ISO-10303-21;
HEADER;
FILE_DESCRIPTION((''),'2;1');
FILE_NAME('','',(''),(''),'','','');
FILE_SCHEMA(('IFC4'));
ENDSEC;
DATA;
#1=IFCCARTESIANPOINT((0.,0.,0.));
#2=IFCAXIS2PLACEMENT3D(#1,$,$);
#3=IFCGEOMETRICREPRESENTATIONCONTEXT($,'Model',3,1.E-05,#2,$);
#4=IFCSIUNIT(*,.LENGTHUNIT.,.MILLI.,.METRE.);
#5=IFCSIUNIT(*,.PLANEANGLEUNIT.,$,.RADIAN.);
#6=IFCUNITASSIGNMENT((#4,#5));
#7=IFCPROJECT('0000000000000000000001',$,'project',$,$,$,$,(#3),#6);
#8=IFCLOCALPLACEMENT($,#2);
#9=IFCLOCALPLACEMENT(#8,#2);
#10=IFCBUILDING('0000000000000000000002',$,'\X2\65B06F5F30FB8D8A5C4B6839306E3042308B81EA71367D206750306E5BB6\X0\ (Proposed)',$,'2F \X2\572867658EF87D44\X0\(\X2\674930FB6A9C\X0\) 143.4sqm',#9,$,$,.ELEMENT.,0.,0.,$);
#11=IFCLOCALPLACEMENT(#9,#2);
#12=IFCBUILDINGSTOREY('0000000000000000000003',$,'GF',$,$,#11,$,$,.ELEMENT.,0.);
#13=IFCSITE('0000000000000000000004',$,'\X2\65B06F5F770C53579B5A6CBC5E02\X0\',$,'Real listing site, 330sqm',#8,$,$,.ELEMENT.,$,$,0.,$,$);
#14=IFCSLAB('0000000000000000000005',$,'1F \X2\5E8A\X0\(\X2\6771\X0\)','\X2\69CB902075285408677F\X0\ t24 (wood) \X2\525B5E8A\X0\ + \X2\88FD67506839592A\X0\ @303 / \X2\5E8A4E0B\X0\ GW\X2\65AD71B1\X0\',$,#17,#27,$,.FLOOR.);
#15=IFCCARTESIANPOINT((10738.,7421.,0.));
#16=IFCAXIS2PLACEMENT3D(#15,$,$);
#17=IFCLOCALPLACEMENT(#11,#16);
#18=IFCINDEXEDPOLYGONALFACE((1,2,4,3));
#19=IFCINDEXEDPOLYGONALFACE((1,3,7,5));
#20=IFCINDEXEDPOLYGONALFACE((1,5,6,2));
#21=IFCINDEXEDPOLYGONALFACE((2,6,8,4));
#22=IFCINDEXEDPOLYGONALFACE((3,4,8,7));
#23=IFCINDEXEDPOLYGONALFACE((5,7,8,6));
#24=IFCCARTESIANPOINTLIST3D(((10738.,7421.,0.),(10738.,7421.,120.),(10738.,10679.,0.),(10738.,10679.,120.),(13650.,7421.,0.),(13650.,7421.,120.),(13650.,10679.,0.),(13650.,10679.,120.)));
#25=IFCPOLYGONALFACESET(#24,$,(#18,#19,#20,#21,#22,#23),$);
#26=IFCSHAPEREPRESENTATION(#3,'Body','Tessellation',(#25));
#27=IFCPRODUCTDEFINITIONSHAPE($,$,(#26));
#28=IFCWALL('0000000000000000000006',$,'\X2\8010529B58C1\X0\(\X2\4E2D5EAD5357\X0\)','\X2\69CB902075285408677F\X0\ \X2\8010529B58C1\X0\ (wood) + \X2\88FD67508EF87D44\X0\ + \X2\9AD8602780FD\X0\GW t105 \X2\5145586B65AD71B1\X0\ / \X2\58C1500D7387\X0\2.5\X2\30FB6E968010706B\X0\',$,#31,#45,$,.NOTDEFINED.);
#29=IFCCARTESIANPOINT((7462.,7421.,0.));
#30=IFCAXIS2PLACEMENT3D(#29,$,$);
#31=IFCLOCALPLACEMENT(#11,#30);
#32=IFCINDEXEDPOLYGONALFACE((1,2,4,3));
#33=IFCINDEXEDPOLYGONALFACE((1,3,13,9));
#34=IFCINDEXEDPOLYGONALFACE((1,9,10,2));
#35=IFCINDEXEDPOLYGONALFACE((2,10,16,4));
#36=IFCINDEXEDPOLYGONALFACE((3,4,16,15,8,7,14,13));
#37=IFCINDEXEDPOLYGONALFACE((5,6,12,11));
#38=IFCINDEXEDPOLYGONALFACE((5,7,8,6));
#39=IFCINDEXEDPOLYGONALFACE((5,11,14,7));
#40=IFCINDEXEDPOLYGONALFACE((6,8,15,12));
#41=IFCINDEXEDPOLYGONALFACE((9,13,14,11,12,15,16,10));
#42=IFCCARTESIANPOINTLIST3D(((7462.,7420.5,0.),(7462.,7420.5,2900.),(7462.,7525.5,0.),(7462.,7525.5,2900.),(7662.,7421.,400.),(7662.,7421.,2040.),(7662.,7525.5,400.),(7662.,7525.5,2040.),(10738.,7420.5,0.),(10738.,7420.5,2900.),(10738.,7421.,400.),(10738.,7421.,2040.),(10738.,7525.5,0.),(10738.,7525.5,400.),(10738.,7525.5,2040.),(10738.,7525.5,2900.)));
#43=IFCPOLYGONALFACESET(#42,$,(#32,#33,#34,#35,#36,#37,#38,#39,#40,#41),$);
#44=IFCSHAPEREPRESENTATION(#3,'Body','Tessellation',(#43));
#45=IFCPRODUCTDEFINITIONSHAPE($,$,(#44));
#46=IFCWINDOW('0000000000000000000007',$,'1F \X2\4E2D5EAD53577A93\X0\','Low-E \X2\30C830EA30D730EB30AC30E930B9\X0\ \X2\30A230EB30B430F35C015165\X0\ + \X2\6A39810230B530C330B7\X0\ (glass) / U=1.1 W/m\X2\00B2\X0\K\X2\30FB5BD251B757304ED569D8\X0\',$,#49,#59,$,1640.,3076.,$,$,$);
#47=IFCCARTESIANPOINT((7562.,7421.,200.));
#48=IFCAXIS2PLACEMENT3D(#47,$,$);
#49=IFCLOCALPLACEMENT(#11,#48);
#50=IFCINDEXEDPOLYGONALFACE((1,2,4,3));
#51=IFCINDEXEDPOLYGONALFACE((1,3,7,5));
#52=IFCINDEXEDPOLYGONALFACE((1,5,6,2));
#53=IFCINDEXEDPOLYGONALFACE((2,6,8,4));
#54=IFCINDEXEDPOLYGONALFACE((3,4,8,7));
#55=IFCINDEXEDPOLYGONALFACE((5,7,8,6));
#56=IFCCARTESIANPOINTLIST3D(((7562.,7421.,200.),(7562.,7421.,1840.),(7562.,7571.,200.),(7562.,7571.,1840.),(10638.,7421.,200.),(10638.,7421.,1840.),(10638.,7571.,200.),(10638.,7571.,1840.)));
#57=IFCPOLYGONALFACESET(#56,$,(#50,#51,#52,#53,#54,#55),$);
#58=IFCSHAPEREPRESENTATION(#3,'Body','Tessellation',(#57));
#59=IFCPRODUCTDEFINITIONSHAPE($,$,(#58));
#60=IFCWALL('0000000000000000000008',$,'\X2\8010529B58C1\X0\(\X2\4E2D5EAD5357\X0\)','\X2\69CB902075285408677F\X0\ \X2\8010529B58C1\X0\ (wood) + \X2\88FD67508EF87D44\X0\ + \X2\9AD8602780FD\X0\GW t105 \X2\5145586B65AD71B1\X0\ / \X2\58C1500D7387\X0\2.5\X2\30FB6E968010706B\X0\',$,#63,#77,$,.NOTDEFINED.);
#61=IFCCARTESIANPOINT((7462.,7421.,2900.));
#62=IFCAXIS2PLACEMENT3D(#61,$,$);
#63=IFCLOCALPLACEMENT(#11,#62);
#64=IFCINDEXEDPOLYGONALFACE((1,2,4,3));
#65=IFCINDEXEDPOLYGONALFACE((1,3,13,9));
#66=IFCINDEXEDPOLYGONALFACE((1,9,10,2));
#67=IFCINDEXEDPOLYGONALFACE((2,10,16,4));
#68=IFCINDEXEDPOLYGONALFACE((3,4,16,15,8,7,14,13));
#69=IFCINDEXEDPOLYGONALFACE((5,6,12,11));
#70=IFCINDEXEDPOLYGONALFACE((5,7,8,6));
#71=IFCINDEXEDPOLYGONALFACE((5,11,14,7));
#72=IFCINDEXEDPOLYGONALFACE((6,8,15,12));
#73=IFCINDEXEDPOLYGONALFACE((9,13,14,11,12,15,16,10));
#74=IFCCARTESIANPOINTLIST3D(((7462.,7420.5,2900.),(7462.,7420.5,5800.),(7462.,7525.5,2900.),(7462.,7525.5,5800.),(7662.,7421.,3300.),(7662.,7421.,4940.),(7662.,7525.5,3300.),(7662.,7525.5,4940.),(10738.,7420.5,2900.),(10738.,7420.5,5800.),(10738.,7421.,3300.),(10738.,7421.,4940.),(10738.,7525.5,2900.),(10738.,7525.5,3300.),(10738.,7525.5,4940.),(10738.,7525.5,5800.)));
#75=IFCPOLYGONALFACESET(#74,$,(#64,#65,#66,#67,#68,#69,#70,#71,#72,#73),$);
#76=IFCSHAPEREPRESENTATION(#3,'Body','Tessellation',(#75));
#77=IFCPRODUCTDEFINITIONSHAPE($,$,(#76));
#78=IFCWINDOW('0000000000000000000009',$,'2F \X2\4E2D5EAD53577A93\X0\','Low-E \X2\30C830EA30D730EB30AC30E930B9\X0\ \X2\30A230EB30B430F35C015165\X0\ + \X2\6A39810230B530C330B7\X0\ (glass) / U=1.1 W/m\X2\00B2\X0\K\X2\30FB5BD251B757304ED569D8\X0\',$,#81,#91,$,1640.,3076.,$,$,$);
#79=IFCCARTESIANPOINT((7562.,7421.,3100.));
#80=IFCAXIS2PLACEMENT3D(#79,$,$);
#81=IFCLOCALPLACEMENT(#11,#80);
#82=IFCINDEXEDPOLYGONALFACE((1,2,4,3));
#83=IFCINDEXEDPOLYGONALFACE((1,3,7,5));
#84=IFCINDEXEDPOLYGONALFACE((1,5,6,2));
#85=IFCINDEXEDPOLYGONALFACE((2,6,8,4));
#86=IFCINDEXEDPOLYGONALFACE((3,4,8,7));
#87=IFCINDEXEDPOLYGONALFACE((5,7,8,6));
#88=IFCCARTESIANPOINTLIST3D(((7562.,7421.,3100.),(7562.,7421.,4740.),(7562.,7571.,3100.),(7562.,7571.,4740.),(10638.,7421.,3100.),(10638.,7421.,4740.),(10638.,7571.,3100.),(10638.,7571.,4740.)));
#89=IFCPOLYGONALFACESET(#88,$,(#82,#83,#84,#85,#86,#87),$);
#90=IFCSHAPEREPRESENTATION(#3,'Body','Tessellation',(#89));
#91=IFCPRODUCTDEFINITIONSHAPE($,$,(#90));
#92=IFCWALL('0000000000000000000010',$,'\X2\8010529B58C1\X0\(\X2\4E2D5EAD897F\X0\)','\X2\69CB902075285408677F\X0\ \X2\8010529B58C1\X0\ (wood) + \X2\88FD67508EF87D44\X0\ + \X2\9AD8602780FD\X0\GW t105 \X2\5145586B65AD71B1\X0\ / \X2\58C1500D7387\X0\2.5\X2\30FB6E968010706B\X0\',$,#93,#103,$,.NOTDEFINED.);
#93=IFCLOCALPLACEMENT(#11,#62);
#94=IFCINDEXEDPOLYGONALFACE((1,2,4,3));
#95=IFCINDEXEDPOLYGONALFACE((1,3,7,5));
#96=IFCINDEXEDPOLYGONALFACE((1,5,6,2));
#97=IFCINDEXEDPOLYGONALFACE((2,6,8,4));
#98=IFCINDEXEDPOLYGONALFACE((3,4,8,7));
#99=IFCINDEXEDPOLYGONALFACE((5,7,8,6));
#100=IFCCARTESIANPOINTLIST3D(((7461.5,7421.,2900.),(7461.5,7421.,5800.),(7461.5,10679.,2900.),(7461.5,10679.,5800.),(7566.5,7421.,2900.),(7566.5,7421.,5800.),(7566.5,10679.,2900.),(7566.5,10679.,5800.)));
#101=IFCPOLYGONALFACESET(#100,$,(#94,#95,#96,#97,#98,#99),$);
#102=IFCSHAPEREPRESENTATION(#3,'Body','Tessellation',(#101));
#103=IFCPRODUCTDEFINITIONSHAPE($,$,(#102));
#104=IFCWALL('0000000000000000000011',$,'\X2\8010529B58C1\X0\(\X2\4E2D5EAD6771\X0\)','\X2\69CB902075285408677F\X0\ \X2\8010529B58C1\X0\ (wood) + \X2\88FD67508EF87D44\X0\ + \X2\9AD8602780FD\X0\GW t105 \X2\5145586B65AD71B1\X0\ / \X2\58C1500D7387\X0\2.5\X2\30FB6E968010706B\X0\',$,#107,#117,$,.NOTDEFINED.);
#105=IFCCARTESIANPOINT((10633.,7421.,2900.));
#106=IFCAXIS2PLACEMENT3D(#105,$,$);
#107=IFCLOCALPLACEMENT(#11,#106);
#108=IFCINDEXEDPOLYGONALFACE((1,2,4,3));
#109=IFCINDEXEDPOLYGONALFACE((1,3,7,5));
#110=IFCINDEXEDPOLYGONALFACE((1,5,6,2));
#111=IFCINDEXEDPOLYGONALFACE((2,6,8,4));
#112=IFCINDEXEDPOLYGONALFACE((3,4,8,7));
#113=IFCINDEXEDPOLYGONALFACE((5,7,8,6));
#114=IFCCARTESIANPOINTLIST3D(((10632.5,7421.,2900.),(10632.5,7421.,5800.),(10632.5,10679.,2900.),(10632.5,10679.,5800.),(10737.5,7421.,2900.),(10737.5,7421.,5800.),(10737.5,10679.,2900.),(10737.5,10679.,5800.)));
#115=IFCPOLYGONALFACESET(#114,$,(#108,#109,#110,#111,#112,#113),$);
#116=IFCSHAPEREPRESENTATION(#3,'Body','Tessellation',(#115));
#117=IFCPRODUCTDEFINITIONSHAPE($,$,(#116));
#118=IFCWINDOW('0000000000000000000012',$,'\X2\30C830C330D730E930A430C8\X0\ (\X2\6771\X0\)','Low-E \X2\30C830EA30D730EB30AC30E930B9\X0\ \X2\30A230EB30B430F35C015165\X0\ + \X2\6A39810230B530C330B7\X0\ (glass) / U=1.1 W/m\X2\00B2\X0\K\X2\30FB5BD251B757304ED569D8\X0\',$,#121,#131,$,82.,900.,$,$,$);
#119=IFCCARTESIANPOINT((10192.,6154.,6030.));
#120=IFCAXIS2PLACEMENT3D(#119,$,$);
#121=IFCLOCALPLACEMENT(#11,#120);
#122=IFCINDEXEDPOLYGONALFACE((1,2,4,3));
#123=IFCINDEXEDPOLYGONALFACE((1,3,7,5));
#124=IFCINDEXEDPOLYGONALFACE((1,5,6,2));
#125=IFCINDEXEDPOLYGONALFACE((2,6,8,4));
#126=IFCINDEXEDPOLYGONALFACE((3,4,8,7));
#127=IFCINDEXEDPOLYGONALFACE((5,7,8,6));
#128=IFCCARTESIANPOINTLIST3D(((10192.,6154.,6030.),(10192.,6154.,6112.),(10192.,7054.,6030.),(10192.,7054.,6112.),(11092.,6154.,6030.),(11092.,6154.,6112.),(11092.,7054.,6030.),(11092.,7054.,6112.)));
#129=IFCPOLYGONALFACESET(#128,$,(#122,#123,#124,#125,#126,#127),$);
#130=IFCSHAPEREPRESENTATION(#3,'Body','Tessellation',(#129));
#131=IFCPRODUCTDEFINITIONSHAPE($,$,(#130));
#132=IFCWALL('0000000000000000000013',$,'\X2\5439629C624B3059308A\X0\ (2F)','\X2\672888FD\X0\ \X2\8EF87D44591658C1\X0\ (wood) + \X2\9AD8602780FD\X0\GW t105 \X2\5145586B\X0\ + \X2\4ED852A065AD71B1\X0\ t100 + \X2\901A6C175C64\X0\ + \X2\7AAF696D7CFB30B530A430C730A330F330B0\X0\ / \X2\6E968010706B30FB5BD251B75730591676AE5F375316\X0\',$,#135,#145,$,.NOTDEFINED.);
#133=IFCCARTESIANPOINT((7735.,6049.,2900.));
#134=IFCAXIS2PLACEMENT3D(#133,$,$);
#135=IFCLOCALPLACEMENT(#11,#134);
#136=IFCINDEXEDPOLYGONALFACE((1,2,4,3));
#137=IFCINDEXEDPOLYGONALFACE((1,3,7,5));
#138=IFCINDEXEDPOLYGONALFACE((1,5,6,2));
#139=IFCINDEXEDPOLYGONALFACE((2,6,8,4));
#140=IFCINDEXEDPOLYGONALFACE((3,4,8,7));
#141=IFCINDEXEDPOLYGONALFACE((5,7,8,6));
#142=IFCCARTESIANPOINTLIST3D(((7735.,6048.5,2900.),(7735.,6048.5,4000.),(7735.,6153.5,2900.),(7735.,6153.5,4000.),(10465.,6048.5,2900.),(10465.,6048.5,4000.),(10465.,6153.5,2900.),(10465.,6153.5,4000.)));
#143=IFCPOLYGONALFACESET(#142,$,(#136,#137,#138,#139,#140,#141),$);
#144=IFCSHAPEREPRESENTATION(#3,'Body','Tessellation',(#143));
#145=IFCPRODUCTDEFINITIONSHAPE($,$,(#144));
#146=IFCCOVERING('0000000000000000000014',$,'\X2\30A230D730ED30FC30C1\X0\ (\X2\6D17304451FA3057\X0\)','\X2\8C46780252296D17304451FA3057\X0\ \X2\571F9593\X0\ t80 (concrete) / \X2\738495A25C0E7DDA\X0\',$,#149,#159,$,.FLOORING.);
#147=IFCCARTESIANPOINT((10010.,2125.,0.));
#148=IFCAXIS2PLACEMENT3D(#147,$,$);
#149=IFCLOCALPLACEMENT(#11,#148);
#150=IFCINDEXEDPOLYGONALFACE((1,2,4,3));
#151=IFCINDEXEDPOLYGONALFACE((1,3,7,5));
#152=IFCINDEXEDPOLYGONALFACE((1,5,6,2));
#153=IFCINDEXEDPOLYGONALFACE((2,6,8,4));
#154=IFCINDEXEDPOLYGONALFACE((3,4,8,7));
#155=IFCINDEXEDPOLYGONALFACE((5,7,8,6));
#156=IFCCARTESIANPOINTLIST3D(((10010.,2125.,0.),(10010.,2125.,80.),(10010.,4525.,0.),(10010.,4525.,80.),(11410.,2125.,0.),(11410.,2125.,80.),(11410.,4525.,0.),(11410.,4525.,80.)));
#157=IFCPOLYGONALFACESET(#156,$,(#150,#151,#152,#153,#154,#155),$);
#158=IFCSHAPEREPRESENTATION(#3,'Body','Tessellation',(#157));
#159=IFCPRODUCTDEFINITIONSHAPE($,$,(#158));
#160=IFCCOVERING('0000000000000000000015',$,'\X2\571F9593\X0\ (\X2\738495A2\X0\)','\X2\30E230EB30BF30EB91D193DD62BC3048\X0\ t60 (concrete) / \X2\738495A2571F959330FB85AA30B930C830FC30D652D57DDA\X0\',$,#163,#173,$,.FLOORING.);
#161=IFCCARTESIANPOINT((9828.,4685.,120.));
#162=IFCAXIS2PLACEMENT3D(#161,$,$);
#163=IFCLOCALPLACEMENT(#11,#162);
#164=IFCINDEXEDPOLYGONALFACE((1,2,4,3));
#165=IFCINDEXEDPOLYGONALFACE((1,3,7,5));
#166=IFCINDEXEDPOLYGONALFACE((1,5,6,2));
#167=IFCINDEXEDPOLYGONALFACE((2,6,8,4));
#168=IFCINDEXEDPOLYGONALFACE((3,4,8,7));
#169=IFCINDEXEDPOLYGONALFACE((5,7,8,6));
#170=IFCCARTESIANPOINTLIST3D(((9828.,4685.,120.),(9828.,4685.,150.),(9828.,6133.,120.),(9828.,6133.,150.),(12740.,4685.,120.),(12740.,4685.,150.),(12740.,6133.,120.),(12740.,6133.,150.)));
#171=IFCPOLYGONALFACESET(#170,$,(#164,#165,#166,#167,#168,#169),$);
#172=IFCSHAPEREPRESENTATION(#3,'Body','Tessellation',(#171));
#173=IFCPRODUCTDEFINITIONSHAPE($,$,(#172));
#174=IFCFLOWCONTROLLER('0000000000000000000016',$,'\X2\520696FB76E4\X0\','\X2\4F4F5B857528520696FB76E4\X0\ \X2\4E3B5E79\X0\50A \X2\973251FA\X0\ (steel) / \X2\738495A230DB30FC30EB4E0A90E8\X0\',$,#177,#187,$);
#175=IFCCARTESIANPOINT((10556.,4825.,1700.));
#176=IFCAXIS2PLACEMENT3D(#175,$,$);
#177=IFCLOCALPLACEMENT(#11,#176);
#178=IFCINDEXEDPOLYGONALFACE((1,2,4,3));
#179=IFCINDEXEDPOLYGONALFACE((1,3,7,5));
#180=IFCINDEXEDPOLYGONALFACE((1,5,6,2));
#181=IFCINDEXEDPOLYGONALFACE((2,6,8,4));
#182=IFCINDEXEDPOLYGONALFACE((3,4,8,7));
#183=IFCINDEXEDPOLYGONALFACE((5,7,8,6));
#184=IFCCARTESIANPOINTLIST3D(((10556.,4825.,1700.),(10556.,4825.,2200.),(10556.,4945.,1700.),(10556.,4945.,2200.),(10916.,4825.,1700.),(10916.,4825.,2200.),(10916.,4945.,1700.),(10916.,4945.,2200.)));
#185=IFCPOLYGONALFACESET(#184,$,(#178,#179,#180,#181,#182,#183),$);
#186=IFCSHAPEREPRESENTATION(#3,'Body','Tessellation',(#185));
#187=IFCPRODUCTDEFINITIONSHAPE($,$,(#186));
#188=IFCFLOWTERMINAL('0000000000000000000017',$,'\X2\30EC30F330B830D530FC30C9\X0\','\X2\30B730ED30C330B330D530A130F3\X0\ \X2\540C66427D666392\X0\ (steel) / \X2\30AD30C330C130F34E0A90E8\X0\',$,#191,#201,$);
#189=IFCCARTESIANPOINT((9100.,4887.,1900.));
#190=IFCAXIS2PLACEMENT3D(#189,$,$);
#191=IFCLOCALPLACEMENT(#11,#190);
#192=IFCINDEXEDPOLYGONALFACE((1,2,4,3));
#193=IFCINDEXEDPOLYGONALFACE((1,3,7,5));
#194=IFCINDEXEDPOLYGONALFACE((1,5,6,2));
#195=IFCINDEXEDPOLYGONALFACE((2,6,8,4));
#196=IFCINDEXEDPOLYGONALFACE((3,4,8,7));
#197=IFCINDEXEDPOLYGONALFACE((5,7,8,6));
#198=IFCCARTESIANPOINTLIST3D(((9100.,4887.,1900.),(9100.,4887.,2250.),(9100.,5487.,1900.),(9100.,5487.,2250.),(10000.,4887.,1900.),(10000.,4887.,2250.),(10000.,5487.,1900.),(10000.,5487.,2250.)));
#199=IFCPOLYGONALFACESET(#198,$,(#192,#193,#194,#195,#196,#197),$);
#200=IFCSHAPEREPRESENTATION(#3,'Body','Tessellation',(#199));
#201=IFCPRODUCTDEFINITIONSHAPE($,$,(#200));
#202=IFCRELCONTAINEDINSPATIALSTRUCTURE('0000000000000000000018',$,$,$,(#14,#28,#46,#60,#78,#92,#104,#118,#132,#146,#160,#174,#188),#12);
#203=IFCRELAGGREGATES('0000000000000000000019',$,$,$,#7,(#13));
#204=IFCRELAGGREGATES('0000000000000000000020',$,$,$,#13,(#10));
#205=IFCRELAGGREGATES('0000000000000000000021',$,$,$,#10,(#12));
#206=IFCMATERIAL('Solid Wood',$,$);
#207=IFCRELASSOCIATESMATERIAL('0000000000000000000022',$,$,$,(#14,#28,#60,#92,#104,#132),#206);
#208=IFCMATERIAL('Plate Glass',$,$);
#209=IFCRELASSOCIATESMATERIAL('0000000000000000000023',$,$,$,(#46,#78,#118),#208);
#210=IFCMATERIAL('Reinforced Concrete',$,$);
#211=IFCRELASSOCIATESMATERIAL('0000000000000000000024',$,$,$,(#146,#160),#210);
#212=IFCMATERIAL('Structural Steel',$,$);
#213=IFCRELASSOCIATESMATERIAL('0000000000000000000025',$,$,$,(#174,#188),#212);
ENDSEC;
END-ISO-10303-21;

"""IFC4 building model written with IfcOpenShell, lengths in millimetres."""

from ifc_helpers import new_model, si_unit, frame, frame_2d, origin, place, context, project, spatial, rectangle, extrude, material, element, fill, save


model = new_model("IFC4")

# Units and contexts
model_context = context("Model", 3, precision=1e-05, world=origin())
ifc_project = project(units=[si_unit("LENGTHUNIT", "METRE", prefix="MILLI"), si_unit("PLANEANGLEUNIT", "RADIAN")], contexts=[model_context])

# Site, building, storey
site_placement = place(None, origin())
site = spatial("IfcSite", under=ifc_project, at=site_placement, Name="新潟県南魚沼市", ObjectType="Real listing site, 330sqm", CompositionType="ELEMENT", RefElevation=0.0)
building_placement = place(site_placement, origin())
building = spatial("IfcBuilding", under=site, at=building_placement, Name="新潟・越屋根のある自然素材の家 (Proposed)", ObjectType="2F 在来軸組(杉・檜) 143.4sqm", CompositionType="ELEMENT", ElevationOfRefHeight=0.0, ElevationOfTerrain=0.0)
storey_placement = place(building_placement, origin())
storey = spatial("IfcBuildingStorey", under=building, at=storey_placement, Name="GF", CompositionType="ELEMENT", Elevation=0.0)

# Shared definitions
ifc_material_1 = material(Name="Solid Wood")

# Slab
slab_placement = place(storey_placement, frame((10738.0, 7421.0, 0.0)))
element("IfcSlab", 1, at=slab_placement, inside=storey, material=ifc_material_1, Name="1F 床(東)", Description="構造用合板 t24 (wood) 剛床 + 製材根太 @303 / 床下 GW断熱", PredefinedType="FLOOR", context=model_context, shape_type="SweptSolid", body=[
    extrude(rectangle(XDim=2912.0, YDim=3258.0, at=frame_2d((1456.0, 1629.0))), frame((10738.0, 7421.0, 0.0)), (0.0, 0.0, 1.0), 120.0),
])

# Wall, opening, window
wall_1_placement = place(storey_placement, frame((7462.0, 7421.0, 0.0)))
wall_1 = element("IfcWall", 2, at=wall_1_placement, inside=storey, material=ifc_material_1, Name="耐力壁(中庭南)", Description="構造用合板 耐力壁 (wood) + 製材軸組 + 高性能GW t105 充填断熱 / 壁倍率2.5・準耐火", PredefinedType="NOTDEFINED", context=model_context, shape_type="SweptSolid", body=[
    extrude(rectangle(XDim=3276.0, YDim=105.0, at=frame_2d((1638.0, 52.0))), frame((7462.0, 7421.0, 0.0)), (0.0, 0.0, 1.0), 2900.0),
])
opening_1_placement = place(storey_placement, frame((7562.0, 7421.0, 200.0)))
opening_1 = element("IfcOpeningElement", 3, at=opening_1_placement, cuts=wall_1, PredefinedType="NOTDEFINED", context=model_context, shape_type="SweptSolid", body=[
    extrude(rectangle(XDim=3076.0, YDim=150.0, at=frame_2d((1538.0, 75.0))), frame((7562.0, 7421.0, 200.0)), (0.0, 0.0, 1.0), 1640.0),
])
ifc_material_2 = material(Name="Plate Glass")
window_1_placement = place(storey_placement, frame((7562.0, 7421.0, 200.0)))
window_1 = element("IfcWindow", 4, at=window_1_placement, inside=storey, material=ifc_material_2, Name="1F 中庭南窓", Description="Low-E トリプルガラス アルゴン封入 + 樹脂サッシ (glass) / U=1.1 W/m²K・寒冷地仕様", OverallHeight=1640.0, OverallWidth=3076.0, context=model_context, shape_type="SweptSolid", body=[
    extrude(rectangle(XDim=3076.0, YDim=150.0, at=frame_2d((1538.0, 75.0))), frame((7562.0, 7421.0, 200.0)), (0.0, 0.0, 1.0), 1640.0),
])
fill(opening_1, window_1)

# Wall, opening, window
wall_2_placement = place(storey_placement, frame((7462.0, 7421.0, 2900.0)))
wall_2 = element("IfcWall", 5, at=wall_2_placement, inside=storey, material=ifc_material_1, Name="耐力壁(中庭南)", Description="構造用合板 耐力壁 (wood) + 製材軸組 + 高性能GW t105 充填断熱 / 壁倍率2.5・準耐火", PredefinedType="NOTDEFINED", context=model_context, shape_type="SweptSolid", body=[
    extrude(rectangle(XDim=3276.0, YDim=105.0, at=frame_2d((1638.0, 52.0))), frame((7462.0, 7421.0, 2900.0)), (0.0, 0.0, 1.0), 2900.0),
])
opening_2_placement = place(storey_placement, frame((7562.0, 7421.0, 3100.0)))
opening_2 = element("IfcOpeningElement", 6, at=opening_2_placement, cuts=wall_2, PredefinedType="NOTDEFINED", context=model_context, shape_type="SweptSolid", body=[
    extrude(rectangle(XDim=3076.0, YDim=150.0, at=frame_2d((1538.0, 75.0))), frame((7562.0, 7421.0, 3100.0)), (0.0, 0.0, 1.0), 1640.0),
])
window_2_placement = place(storey_placement, frame((7562.0, 7421.0, 3100.0)))
window_2 = element("IfcWindow", 7, at=window_2_placement, inside=storey, material=ifc_material_2, Name="2F 中庭南窓", Description="Low-E トリプルガラス アルゴン封入 + 樹脂サッシ (glass) / U=1.1 W/m²K・寒冷地仕様", OverallHeight=1640.0, OverallWidth=3076.0, context=model_context, shape_type="SweptSolid", body=[
    extrude(rectangle(XDim=3076.0, YDim=150.0, at=frame_2d((1538.0, 75.0))), frame((7562.0, 7421.0, 3100.0)), (0.0, 0.0, 1.0), 1640.0),
])
fill(opening_2, window_2)

# Walls
wall_3_placement = place(storey_placement, frame((7462.0, 7421.0, 2900.0)))
element("IfcWall", 8, at=wall_3_placement, inside=storey, material=ifc_material_1, Name="耐力壁(中庭西)", Description="構造用合板 耐力壁 (wood) + 製材軸組 + 高性能GW t105 充填断熱 / 壁倍率2.5・準耐火", PredefinedType="NOTDEFINED", context=model_context, shape_type="SweptSolid", body=[
    extrude(rectangle(XDim=105.0, YDim=3258.0, at=frame_2d((52.0, 1629.0))), frame((7462.0, 7421.0, 2900.0)), (0.0, 0.0, 1.0), 2900.0),
])
wall_4_placement = place(storey_placement, frame((10633.0, 7421.0, 2900.0)))
element("IfcWall", 9, at=wall_4_placement, inside=storey, material=ifc_material_1, Name="耐力壁(中庭東)", Description="構造用合板 耐力壁 (wood) + 製材軸組 + 高性能GW t105 充填断熱 / 壁倍率2.5・準耐火", PredefinedType="NOTDEFINED", context=model_context, shape_type="SweptSolid", body=[
    extrude(rectangle(XDim=105.0, YDim=3258.0, at=frame_2d((52.0, 1629.0))), frame((10633.0, 7421.0, 2900.0)), (0.0, 0.0, 1.0), 2900.0),
])

# Window
window_3_placement = place(storey_placement, frame((10192.0, 6154.0, 6030.0)))
element("IfcWindow", 10, at=window_3_placement, inside=storey, material=ifc_material_2, Name="トップライト (東)", Description="Low-E トリプルガラス アルゴン封入 + 樹脂サッシ (glass) / U=1.1 W/m²K・寒冷地仕様", OverallHeight=82.0, OverallWidth=900.0, context=model_context, shape_type="SweptSolid", body=[
    extrude(rectangle(XDim=900.0, YDim=900.0, at=frame_2d((450.0, 450.0))), frame((10192.0, 6154.0, 6030.0)), (0.0, 0.0, 1.0), 82.0),
])

# Wall
wall_5_placement = place(storey_placement, frame((7735.0, 6049.0, 2900.0)))
element("IfcWall", 11, at=wall_5_placement, inside=storey, material=ifc_material_1, Name="吹抜手すり (2F)", Description="木製 軸組外壁 (wood) + 高性能GW t105 充填 + 付加断熱 t100 + 通気層 + 窯業系サイディング / 準耐火・寒冷地外皮強化", PredefinedType="NOTDEFINED", context=model_context, shape_type="SweptSolid", body=[
    extrude(rectangle(XDim=2730.0, YDim=105.0, at=frame_2d((1365.0, 52.0))), frame((7735.0, 6049.0, 2900.0)), (0.0, 0.0, 1.0), 1100.0),
])

# Coverings
ifc_material_3 = material(Name="Reinforced Concrete")
covering_1_placement = place(storey_placement, frame((10010.0, 2125.0, 0.0)))
element("IfcCovering", 12, at=covering_1_placement, inside=storey, material=ifc_material_3, Name="アプローチ (洗い出し)", Description="豆砂利洗い出し 土間 t80 (concrete) / 玄関導線", PredefinedType="FLOORING", context=model_context, shape_type="SweptSolid", body=[
    extrude(rectangle(XDim=1400.0, YDim=2400.0, at=frame_2d((700.0, 1200.0))), frame((10010.0, 2125.0, 0.0)), (0.0, 0.0, 1.0), 80.0),
])
covering_2_placement = place(storey_placement, frame((9828.0, 4685.0, 120.0)))
element("IfcCovering", 13, at=covering_2_placement, inside=storey, material=ifc_material_3, Name="土間 (玄関)", Description="モルタル金鏝押え t60 (concrete) / 玄関土間・薪ストーブ動線", PredefinedType="FLOORING", context=model_context, shape_type="SweptSolid", body=[
    extrude(rectangle(XDim=2912.0, YDim=1448.0, at=frame_2d((1456.0, 724.0))), frame((9828.0, 4685.0, 120.0)), (0.0, 0.0, 1.0), 30.0),
])

# Flow controller
ifc_material_4 = material(Name="Structural Steel")
flow_controller_placement = place(storey_placement, frame((10556.0, 4825.0, 1700.0)))
element("IfcFlowController", 14, at=flow_controller_placement, inside=storey, material=ifc_material_4, Name="分電盤", Description="住宅用分電盤 主幹50A 露出 (steel) / 玄関ホール上部", context=model_context, shape_type="SweptSolid", body=[
    extrude(rectangle(XDim=360.0, YDim=120.0, at=frame_2d((180.0, 60.0))), frame((10556.0, 4825.0, 1700.0)), (0.0, 0.0, 1.0), 500.0),
])

# Flow terminal
flow_terminal_1_placement = place(storey_placement, frame((9100.0, 4887.0, 1900.0)))
element("IfcFlowTerminal", 15, at=flow_terminal_1_placement, inside=storey, material=ifc_material_4, Name="レンジフード", Description="シロッコファン 同時給排 (steel) / キッチン上部", context=model_context, shape_type="SweptSolid", body=[
    extrude(rectangle(XDim=900.0, YDim=600.0, at=frame_2d((450.0, 300.0))), frame((9100.0, 4887.0, 1900.0)), (0.0, 0.0, 1.0), 350.0),
])

save(model, "model.ifc")
